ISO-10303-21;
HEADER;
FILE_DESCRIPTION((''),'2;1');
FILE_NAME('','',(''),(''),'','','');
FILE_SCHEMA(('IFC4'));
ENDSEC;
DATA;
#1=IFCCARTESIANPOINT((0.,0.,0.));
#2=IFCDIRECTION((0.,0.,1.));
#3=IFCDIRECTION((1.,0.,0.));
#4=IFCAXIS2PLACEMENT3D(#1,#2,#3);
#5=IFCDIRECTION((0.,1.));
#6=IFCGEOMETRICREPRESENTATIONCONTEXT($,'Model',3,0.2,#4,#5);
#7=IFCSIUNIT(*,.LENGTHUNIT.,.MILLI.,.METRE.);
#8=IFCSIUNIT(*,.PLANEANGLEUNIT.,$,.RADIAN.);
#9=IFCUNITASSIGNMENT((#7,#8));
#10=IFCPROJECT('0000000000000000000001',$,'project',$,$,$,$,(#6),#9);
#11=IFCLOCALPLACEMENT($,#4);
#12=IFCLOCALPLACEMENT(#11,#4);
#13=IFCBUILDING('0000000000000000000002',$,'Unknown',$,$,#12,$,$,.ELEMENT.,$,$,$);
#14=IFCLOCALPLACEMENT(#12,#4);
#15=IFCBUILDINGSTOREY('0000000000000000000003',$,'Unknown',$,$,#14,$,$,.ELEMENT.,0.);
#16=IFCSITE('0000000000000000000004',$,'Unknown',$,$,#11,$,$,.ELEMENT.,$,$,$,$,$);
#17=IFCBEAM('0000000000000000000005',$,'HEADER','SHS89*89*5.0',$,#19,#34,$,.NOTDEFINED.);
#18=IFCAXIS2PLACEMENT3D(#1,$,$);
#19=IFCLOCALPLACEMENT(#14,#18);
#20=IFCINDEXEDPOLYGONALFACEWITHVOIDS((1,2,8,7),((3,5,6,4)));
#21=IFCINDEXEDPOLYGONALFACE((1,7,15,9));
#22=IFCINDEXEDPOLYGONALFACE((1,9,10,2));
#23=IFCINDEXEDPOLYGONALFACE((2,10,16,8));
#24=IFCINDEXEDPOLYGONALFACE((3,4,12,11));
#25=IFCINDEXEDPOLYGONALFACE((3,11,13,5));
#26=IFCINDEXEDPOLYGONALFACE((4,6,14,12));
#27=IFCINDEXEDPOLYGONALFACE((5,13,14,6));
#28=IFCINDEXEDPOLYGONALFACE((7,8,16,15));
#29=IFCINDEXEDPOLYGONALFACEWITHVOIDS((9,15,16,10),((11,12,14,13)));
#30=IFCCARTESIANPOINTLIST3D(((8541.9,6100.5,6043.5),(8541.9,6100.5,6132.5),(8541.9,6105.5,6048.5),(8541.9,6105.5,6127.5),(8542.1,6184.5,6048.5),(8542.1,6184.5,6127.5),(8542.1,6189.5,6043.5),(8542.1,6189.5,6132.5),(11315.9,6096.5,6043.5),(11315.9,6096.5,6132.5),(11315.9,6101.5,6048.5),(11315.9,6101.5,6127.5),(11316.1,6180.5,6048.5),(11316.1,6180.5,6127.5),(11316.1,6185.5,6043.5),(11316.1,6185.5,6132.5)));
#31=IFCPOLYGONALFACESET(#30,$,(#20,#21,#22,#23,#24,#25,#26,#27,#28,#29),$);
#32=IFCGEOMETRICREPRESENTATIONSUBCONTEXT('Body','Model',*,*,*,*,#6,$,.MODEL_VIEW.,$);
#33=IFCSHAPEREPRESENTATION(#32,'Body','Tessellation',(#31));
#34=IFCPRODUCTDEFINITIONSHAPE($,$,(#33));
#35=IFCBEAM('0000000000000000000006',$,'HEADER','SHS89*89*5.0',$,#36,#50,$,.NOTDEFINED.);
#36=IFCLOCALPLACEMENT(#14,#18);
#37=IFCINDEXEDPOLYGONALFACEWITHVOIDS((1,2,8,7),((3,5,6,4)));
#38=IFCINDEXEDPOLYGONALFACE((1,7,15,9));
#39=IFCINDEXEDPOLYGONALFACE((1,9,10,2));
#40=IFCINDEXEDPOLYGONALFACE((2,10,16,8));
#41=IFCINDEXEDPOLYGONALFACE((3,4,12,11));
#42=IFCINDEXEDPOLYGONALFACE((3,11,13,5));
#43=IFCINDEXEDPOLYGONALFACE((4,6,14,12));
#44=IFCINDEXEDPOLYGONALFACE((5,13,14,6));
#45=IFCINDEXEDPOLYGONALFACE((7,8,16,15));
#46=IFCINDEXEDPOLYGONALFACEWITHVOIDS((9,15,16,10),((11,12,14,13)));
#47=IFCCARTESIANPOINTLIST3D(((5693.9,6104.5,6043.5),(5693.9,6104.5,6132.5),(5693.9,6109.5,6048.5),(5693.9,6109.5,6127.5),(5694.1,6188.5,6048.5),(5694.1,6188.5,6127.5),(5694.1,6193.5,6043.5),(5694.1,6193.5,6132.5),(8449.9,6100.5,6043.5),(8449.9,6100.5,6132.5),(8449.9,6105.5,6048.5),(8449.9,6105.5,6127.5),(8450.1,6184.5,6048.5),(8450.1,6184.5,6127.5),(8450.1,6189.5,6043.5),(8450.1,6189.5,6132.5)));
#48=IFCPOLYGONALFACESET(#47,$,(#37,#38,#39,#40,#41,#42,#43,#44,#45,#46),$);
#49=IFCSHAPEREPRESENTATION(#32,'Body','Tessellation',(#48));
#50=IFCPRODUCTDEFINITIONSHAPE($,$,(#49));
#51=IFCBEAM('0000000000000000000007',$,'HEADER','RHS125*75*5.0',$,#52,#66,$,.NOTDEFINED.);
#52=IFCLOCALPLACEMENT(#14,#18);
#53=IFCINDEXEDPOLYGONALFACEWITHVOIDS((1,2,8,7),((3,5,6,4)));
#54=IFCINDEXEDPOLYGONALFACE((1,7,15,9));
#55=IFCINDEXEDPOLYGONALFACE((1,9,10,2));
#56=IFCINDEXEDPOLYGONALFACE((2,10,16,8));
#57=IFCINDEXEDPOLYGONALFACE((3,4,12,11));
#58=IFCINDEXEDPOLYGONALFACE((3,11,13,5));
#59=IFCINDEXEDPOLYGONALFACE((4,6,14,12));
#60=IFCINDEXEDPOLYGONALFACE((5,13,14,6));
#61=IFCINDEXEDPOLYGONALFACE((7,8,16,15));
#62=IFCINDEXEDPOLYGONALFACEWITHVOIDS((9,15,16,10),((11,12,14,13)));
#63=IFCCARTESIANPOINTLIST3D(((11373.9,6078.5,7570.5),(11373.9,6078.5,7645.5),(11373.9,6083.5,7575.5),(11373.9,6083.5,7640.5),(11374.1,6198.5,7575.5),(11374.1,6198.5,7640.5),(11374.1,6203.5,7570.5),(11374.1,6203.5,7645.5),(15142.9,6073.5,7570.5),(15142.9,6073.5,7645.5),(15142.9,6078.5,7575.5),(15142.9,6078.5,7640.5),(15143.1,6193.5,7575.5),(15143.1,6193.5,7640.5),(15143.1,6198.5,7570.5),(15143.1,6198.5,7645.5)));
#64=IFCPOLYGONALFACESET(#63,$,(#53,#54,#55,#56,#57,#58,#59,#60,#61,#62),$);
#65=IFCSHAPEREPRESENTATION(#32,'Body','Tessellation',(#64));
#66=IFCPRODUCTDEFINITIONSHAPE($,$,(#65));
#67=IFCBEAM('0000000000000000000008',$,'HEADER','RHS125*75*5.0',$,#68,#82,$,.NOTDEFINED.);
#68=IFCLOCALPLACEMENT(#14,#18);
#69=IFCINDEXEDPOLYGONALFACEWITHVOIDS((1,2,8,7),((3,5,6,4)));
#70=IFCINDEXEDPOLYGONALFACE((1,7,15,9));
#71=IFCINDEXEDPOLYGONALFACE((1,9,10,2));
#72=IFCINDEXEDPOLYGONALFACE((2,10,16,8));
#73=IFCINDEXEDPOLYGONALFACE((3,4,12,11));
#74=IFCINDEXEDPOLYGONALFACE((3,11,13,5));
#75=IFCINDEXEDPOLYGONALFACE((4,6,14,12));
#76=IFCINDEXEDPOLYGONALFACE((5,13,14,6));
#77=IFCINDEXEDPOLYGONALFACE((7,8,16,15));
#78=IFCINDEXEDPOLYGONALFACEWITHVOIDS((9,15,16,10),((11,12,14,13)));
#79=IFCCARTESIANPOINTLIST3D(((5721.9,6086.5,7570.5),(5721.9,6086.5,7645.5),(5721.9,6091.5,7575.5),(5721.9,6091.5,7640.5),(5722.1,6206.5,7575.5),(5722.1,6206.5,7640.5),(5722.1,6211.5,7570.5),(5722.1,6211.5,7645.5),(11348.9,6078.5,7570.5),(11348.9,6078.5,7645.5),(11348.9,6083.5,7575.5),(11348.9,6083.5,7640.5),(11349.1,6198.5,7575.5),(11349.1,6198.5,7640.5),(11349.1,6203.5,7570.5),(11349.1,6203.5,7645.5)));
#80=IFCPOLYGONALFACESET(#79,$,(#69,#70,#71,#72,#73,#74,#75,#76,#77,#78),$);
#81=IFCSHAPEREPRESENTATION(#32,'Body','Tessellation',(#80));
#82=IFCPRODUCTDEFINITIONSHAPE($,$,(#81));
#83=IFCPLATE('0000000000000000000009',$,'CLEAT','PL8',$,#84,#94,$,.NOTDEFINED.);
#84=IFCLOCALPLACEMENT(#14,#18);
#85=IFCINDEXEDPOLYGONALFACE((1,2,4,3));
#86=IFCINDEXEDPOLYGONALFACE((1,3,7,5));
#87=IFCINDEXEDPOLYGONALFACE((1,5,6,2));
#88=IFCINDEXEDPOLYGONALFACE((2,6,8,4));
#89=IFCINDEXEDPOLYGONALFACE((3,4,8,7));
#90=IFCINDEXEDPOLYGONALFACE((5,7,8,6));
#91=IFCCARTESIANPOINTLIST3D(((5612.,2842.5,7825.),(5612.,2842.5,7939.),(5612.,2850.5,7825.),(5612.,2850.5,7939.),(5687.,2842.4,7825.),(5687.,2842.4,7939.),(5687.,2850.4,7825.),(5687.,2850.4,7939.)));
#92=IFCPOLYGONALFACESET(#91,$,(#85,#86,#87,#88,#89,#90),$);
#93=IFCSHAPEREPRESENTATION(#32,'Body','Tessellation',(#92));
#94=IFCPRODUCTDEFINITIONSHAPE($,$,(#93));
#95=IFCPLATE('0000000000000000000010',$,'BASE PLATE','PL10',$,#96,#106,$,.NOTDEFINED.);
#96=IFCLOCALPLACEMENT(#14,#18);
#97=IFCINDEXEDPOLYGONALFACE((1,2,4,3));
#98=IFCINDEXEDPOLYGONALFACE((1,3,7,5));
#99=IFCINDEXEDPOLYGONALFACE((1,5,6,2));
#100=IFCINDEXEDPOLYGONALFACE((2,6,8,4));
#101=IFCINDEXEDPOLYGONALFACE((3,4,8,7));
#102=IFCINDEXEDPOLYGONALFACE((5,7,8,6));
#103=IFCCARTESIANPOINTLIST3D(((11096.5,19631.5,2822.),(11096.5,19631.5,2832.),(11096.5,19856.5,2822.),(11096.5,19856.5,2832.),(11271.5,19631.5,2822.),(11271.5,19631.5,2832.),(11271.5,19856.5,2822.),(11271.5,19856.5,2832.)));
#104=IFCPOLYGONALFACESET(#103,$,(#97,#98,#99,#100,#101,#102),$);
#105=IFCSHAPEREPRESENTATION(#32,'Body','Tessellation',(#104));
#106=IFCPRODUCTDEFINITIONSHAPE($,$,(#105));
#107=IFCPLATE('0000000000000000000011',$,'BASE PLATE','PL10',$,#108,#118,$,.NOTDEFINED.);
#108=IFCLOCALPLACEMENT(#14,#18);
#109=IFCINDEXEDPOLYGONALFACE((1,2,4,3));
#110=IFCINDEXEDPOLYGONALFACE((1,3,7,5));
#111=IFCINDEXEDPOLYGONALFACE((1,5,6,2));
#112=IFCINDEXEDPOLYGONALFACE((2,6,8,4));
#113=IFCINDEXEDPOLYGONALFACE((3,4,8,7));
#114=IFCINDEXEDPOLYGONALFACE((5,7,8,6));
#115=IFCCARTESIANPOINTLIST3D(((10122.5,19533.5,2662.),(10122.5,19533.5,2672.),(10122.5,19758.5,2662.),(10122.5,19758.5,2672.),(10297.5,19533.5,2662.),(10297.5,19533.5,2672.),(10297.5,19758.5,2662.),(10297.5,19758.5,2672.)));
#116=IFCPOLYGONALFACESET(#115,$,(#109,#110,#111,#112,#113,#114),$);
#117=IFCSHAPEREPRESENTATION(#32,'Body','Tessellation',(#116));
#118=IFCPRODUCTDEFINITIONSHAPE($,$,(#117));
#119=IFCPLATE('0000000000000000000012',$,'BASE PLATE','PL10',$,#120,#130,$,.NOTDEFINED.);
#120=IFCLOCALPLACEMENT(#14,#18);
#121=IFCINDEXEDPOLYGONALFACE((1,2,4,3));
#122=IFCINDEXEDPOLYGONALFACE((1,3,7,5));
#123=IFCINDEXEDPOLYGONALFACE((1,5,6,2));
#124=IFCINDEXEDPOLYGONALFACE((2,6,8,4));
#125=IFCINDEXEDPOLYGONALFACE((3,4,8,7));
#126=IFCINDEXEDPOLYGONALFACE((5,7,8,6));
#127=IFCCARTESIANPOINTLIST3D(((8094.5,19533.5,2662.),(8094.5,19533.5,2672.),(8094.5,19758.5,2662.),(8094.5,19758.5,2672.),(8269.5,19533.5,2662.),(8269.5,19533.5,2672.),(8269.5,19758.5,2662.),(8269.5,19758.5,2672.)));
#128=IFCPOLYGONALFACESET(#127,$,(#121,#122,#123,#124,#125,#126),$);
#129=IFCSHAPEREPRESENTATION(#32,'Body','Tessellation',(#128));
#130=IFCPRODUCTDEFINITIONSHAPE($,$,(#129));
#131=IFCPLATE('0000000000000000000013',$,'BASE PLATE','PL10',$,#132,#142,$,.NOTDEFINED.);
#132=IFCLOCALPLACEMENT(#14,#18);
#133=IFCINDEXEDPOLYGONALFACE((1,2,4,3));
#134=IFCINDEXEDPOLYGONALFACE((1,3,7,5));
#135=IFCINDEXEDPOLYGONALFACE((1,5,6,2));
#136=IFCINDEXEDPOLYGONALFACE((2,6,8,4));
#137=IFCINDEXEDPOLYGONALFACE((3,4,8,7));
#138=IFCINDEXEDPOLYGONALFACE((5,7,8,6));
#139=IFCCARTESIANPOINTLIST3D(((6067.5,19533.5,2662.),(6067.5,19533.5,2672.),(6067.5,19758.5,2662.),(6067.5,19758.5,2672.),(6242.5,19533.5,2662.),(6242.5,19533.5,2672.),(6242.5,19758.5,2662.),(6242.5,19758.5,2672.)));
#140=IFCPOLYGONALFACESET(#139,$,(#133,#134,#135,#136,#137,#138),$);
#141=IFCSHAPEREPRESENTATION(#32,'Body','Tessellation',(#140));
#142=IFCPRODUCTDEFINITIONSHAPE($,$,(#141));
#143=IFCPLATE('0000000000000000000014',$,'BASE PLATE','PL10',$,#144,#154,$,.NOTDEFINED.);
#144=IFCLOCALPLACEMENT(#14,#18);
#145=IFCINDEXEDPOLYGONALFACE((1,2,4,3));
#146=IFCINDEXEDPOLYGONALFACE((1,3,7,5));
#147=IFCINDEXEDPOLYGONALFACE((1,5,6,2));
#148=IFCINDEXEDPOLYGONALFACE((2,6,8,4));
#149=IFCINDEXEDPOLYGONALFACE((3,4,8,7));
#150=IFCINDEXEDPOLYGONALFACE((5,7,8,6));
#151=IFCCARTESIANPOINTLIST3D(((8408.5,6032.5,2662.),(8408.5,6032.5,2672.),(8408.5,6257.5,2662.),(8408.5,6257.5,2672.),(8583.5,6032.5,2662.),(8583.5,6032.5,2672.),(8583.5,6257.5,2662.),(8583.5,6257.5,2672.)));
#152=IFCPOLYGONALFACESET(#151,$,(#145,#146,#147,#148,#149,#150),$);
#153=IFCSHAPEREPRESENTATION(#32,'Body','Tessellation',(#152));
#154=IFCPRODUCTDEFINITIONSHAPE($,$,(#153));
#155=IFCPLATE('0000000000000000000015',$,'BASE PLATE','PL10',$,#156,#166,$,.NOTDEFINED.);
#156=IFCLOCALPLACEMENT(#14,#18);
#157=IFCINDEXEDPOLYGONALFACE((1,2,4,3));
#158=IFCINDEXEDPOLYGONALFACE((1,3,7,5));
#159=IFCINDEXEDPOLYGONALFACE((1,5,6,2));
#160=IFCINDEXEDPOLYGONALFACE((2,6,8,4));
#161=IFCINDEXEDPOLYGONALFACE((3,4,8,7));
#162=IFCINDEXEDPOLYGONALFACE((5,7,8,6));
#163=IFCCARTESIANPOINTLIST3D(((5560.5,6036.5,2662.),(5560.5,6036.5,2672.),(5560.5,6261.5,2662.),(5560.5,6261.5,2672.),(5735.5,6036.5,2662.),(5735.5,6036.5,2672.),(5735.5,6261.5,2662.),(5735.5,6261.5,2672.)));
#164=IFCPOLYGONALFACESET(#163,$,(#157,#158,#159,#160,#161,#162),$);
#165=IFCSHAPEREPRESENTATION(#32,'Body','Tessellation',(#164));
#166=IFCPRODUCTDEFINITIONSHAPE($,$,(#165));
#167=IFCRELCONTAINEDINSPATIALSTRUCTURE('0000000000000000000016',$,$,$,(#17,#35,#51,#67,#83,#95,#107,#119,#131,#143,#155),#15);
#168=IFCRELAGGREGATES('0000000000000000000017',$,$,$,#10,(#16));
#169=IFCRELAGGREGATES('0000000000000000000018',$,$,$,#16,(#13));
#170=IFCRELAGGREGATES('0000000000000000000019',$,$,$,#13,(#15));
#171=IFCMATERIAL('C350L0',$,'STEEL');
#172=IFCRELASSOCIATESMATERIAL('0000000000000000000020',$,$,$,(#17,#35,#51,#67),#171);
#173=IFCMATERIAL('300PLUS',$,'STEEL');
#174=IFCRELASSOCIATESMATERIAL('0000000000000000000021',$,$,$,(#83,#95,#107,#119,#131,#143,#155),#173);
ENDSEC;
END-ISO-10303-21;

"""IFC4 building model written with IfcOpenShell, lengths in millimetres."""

from ifc_helpers import new_model, si_unit, direction, frame, origin_with_axes, place, context, subcontext, project, spatial, line, indexed_curve, outline, extrude, material, element, save


model = new_model("IFC4")

# Units and contexts
model_context = context("Model", 3, precision=0.2, world=origin_with_axes(), true_north=direction((0.0, 1.0)))
body_context = subcontext(model_context, "Body", "Model", "MODEL_VIEW")
ifc_project = project(units=[si_unit("LENGTHUNIT", "METRE", prefix="MILLI"), si_unit("PLANEANGLEUNIT", "RADIAN")], contexts=[model_context])

# Site, building, storey
site_placement = place(None, origin_with_axes())
site = spatial("IfcSite", under=ifc_project, at=site_placement, Name="Unknown", CompositionType="ELEMENT")
building_placement = place(site_placement, origin_with_axes())
building = spatial("IfcBuilding", under=site, at=building_placement, Name="Unknown", CompositionType="ELEMENT")
storey_placement = place(building_placement, origin_with_axes())
storey = spatial("IfcBuildingStorey", under=building, at=storey_placement, Name="Unknown", CompositionType="ELEMENT", Elevation=0.0)

# Shared definitions
ifc_material_1 = material(Name="C350L0", Category="STEEL")

# Beams
beam_1_placement = place(storey_placement, frame((8542.0, 6145.0, 6088.0), z_axis=(0.0, 0.0, 1.0), x_axis=(0.999999, -0.001442, 0.0)))
element("IfcBeam", 1, at=beam_1_placement, inside=storey, material=ifc_material_1, Name="HEADER", Description="SHS89*89*5.0", PredefinedType="NOTDEFINED", context=body_context, shape_type="SolidModel", body=[
    extrude(outline(indexed_curve([(-44.5, -44.5), (44.5, -44.5), (44.5, 44.5), (-44.5, 44.5)], segments=[line(1, 2, 3, 4, 1)]), holes=[indexed_curve([(-39.5, -39.5), (-39.5, 39.5), (39.5, 39.5), (39.5, -39.5)], segments=[line(1, 2, 3, 4, 1)])]), frame((0.0, 0.0, 0.0), z_axis=(-1.0, 0.0, 0.0), x_axis=(0.0, 0.0, 1.0)), (0.0, 0.0, -1.0), 2774.0),
])
beam_2_placement = place(storey_placement, frame((5694.0, 6149.0, 6088.0), z_axis=(0.0, 0.0, 1.0), x_axis=(0.999999, -0.001451, 0.0)))
element("IfcBeam", 2, at=beam_2_placement, inside=storey, material=ifc_material_1, Name="HEADER", Description="SHS89*89*5.0", PredefinedType="NOTDEFINED", context=body_context, shape_type="SolidModel", body=[
    extrude(outline(indexed_curve([(-44.5, -44.5), (44.5, -44.5), (44.5, 44.5), (-44.5, 44.5)], segments=[line(1, 2, 3, 4, 1)]), holes=[indexed_curve([(-39.5, -39.5), (-39.5, 39.5), (39.5, 39.5), (39.5, -39.5)], segments=[line(1, 2, 3, 4, 1)])]), frame((0.0, 0.0, 0.0), z_axis=(-1.0, 0.0, 0.0), x_axis=(0.0, 0.0, 1.0)), (0.0, 0.0, -1.0), 2756.0),
])
beam_3_placement = place(storey_placement, frame((11374.0, 6141.0, 7608.0), z_axis=(0.0, 0.0, 1.0), x_axis=(0.999999, -0.001327, 0.0)))
element("IfcBeam", 3, at=beam_3_placement, inside=storey, material=ifc_material_1, Name="HEADER", Description="RHS125*75*5.0", PredefinedType="NOTDEFINED", context=body_context, shape_type="SolidModel", body=[
    extrude(outline(indexed_curve([(-37.5, -62.5), (37.5, -62.5), (37.5, 62.5), (-37.5, 62.5)], segments=[line(1, 2, 3, 4, 1)]), holes=[indexed_curve([(-32.5, -57.5), (-32.5, 57.5), (32.5, 57.5), (32.5, -57.5)], segments=[line(1, 2, 3, 4, 1)])]), frame((0.0, 0.0, 0.0), z_axis=(-1.0, 0.0, 0.0), x_axis=(0.0, 0.0, 1.0)), (0.0, 0.0, -1.0), 3769.0),
])
beam_4_placement = place(storey_placement, frame((5722.0, 6149.0, 7608.0), z_axis=(0.0, 0.0, 1.0), x_axis=(0.999999, -0.001422, 0.0)))
element("IfcBeam", 4, at=beam_4_placement, inside=storey, material=ifc_material_1, Name="HEADER", Description="RHS125*75*5.0", PredefinedType="NOTDEFINED", context=body_context, shape_type="SolidModel", body=[
    extrude(outline(indexed_curve([(-37.5, -62.5), (37.5, -62.5), (37.5, 62.5), (-37.5, 62.5)], segments=[line(1, 2, 3, 4, 1)]), holes=[indexed_curve([(-32.5, -57.5), (-32.5, 57.5), (32.5, 57.5), (32.5, -57.5)], segments=[line(1, 2, 3, 4, 1)])]), frame((0.0, 0.0, 0.0), z_axis=(-1.0, 0.0, 0.0), x_axis=(0.0, 0.0, 1.0)), (0.0, 0.0, -1.0), 5627.0),
])

# Plates
ifc_material_2 = material(Name="300PLUS", Category="STEEL")
plate_placement = place(storey_placement, frame((5612.0, 2846.5, 7939.0), z_axis=(0.001333, 0.999999, 0.0), x_axis=(0.999999, -0.001333, 0.0)))
element("IfcPlate", 5, at=plate_placement, inside=storey, material=ifc_material_2, Name="CLEAT", Description="PL8", PredefinedType="NOTDEFINED", context=body_context, shape_type="SolidModel", body=[
    extrude(outline(indexed_curve([(0.0, 0.0), (75.0, 0.0), (75.0, 114.0), (0.0, 114.0)], segments=[line(1, 2, 3, 4, 1)])), frame((0.0, 0.0, 4.0), z_axis=(0.0, 0.0, 1.0), x_axis=(1.0, 0.0, 0.0)), (0.0, 0.0, -1.0), 8.0),
])
for number, where, z_axis, x_axis, name in (
    (6, (11271.5, 19631.5, 2827.0), (0.0, 0.0, 1.0), (0.0, 1.0, 0.0), "BASE PLATE"),
    (7, (10297.5, 19533.5, 2667.0), (0.0, 0.0, 1.0), (0.0, 1.0, 0.0), "BASE PLATE"),
    (8, (8269.5, 19533.5, 2667.0), (0.0, 0.0, 1.0), (0.0, 1.0, 0.0), "BASE PLATE"),
    (9, (6242.5, 19533.5, 2667.0), (0.0, 0.0, 1.0), (0.0, 1.0, 0.0), "BASE PLATE"),
    (10, (8583.5, 6032.5, 2667.0), (0.0, 0.0, 1.0), (0.0, 1.0, 0.0), "BASE PLATE"),
    (11, (5735.5, 6036.5, 2667.0), (0.0, 0.0, 1.0), (0.0, 1.0, 0.0), "BASE PLATE"),
):
    element("IfcPlate", number, at=place(storey_placement, frame(where, z_axis=z_axis, x_axis=x_axis)), inside=storey, material=ifc_material_2, Name=name, Description="PL10", PredefinedType="NOTDEFINED", context=body_context, shape_type="SolidModel", body=[
        extrude(outline(indexed_curve([(0.0, 0.0), (225.0, 0.0), (225.0, 175.0), (0.0, 175.0)], segments=[line(1, 2, 3, 4, 1)])), frame((0.0, 0.0, 5.0), z_axis=(0.0, 0.0, 1.0), x_axis=(1.0, 0.0, 0.0)), (0.0, 0.0, -1.0), 10.0),
    ])

save(model, "model.ifc")
